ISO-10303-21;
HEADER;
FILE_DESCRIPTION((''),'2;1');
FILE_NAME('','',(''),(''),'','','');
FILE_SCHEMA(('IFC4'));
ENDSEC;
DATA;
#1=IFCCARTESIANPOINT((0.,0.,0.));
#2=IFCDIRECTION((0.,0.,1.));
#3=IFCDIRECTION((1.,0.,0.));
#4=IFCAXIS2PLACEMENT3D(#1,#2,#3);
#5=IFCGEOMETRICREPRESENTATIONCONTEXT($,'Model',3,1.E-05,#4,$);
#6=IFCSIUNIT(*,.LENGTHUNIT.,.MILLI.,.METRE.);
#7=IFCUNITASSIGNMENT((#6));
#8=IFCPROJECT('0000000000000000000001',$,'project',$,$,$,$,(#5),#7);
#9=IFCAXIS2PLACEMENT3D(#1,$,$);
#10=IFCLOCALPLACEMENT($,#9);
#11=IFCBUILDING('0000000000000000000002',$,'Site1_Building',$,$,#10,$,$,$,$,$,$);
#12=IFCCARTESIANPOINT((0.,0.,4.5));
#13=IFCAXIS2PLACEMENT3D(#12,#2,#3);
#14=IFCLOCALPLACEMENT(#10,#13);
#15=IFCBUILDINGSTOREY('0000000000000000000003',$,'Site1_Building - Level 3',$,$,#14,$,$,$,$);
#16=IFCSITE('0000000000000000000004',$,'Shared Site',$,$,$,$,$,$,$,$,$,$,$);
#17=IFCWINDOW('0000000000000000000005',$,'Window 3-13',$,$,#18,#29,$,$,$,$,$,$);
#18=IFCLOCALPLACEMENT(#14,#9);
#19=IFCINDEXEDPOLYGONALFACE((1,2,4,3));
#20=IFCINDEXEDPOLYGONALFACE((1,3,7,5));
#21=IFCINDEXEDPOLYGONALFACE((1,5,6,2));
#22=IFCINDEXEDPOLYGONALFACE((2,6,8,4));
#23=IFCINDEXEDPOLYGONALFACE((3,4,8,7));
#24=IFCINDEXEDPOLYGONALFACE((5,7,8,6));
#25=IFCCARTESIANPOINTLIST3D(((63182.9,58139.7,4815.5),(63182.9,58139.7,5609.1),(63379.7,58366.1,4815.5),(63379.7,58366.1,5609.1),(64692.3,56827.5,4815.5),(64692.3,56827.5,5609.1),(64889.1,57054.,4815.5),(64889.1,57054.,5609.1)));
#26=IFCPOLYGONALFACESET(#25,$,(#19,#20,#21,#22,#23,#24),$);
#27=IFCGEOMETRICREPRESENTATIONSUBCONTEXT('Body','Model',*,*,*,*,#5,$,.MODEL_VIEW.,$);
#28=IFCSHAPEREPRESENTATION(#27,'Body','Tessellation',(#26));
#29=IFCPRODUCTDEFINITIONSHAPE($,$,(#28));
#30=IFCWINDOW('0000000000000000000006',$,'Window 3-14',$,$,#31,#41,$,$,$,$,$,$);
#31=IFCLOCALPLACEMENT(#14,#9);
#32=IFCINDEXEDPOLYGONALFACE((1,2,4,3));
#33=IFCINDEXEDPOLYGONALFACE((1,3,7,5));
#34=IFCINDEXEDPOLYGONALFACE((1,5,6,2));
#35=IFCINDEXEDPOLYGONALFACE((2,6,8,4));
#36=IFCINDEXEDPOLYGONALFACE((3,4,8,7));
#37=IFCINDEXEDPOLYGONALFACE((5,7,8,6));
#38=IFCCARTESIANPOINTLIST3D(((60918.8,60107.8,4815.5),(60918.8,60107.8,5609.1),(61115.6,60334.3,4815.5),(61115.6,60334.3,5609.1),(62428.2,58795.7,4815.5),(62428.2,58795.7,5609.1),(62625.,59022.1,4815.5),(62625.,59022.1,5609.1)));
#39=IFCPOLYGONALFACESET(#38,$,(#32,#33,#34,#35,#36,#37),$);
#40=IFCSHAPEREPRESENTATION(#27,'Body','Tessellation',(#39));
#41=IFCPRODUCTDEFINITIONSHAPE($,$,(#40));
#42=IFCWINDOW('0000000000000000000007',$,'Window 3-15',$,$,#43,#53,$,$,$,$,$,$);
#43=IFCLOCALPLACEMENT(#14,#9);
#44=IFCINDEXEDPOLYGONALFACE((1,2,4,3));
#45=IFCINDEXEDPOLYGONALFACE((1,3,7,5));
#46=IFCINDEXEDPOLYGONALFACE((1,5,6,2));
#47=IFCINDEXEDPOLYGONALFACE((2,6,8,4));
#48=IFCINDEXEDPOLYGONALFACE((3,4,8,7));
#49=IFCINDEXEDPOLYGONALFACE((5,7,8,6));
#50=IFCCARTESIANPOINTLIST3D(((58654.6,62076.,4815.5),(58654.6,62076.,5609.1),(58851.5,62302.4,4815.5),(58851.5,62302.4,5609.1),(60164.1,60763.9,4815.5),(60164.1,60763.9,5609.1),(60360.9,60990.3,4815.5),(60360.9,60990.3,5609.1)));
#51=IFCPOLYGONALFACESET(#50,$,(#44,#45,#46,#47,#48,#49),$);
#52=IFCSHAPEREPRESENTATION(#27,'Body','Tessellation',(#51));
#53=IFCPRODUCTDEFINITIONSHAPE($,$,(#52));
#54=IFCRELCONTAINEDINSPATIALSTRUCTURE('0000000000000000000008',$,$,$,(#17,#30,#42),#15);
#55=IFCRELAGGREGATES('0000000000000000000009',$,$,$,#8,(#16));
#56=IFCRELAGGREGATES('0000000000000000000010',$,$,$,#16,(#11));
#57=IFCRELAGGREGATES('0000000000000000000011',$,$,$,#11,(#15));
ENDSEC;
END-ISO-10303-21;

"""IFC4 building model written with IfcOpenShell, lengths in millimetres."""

from ifc_helpers import new_model, si_unit, frame, origin, origin_with_axes, place, context, subcontext, project, spatial, indexed_curve, outline, extrude, element, save


model = new_model("IFC4")

# Units and contexts
model_context = context("Model", 3, precision=1e-05, world=origin_with_axes())
body_context = subcontext(model_context, "Body", "Model", "MODEL_VIEW")
ifc_project = project(units=[si_unit("LENGTHUNIT", "METRE", prefix="MILLI")], contexts=[model_context])

# Site, building, storey
site = spatial("IfcSite", under=ifc_project, Name="Shared Site")
building_placement = place(None, origin())
building = spatial("IfcBuilding", under=site, at=building_placement, Name="Site1_Building")
storey_placement = place(building_placement, frame((0.0, 0.0, 4.5), z_axis=(0.0, 0.0, 1.0), x_axis=(1.0, 0.0, 0.0)))
storey = spatial("IfcBuildingStorey", under=building, at=storey_placement, Name="Site1_Building - Level 3")

# Windows
for number, where, z_axis, x_axis, name in (
    (1, (64889.1, 57054.0, 4815.5), (0.0, 0.0, 1.0), (-0.75471, 0.656059, 0.0), "Window 3-13"),
    (2, (62625.0, 59022.1, 4815.5), (0.0, 0.0, 1.0), (-0.75471, 0.656059, 0.0), "Window 3-14"),
    (3, (60360.9, 60990.3, 4815.5), (0.0, 0.0, 1.0), (-0.75471, 0.656059, 0.0), "Window 3-15"),
):
    element("IfcWindow", number, at=place(storey_placement, frame(where, z_axis=z_axis, x_axis=x_axis)), inside=storey, Name=name, context=body_context, shape_type="SweptSolid", body=[
        extrude(outline(indexed_curve([(0.0, 0.0), (0.0, 300.0), (2000.0, 300.0), (2000.0, 0.0), (0.0, 0.0)], self_intersect=False)), origin_with_axes(), (0.0, 0.0, 1.0), 793.6),
    ])

save(model, "model.ifc")
